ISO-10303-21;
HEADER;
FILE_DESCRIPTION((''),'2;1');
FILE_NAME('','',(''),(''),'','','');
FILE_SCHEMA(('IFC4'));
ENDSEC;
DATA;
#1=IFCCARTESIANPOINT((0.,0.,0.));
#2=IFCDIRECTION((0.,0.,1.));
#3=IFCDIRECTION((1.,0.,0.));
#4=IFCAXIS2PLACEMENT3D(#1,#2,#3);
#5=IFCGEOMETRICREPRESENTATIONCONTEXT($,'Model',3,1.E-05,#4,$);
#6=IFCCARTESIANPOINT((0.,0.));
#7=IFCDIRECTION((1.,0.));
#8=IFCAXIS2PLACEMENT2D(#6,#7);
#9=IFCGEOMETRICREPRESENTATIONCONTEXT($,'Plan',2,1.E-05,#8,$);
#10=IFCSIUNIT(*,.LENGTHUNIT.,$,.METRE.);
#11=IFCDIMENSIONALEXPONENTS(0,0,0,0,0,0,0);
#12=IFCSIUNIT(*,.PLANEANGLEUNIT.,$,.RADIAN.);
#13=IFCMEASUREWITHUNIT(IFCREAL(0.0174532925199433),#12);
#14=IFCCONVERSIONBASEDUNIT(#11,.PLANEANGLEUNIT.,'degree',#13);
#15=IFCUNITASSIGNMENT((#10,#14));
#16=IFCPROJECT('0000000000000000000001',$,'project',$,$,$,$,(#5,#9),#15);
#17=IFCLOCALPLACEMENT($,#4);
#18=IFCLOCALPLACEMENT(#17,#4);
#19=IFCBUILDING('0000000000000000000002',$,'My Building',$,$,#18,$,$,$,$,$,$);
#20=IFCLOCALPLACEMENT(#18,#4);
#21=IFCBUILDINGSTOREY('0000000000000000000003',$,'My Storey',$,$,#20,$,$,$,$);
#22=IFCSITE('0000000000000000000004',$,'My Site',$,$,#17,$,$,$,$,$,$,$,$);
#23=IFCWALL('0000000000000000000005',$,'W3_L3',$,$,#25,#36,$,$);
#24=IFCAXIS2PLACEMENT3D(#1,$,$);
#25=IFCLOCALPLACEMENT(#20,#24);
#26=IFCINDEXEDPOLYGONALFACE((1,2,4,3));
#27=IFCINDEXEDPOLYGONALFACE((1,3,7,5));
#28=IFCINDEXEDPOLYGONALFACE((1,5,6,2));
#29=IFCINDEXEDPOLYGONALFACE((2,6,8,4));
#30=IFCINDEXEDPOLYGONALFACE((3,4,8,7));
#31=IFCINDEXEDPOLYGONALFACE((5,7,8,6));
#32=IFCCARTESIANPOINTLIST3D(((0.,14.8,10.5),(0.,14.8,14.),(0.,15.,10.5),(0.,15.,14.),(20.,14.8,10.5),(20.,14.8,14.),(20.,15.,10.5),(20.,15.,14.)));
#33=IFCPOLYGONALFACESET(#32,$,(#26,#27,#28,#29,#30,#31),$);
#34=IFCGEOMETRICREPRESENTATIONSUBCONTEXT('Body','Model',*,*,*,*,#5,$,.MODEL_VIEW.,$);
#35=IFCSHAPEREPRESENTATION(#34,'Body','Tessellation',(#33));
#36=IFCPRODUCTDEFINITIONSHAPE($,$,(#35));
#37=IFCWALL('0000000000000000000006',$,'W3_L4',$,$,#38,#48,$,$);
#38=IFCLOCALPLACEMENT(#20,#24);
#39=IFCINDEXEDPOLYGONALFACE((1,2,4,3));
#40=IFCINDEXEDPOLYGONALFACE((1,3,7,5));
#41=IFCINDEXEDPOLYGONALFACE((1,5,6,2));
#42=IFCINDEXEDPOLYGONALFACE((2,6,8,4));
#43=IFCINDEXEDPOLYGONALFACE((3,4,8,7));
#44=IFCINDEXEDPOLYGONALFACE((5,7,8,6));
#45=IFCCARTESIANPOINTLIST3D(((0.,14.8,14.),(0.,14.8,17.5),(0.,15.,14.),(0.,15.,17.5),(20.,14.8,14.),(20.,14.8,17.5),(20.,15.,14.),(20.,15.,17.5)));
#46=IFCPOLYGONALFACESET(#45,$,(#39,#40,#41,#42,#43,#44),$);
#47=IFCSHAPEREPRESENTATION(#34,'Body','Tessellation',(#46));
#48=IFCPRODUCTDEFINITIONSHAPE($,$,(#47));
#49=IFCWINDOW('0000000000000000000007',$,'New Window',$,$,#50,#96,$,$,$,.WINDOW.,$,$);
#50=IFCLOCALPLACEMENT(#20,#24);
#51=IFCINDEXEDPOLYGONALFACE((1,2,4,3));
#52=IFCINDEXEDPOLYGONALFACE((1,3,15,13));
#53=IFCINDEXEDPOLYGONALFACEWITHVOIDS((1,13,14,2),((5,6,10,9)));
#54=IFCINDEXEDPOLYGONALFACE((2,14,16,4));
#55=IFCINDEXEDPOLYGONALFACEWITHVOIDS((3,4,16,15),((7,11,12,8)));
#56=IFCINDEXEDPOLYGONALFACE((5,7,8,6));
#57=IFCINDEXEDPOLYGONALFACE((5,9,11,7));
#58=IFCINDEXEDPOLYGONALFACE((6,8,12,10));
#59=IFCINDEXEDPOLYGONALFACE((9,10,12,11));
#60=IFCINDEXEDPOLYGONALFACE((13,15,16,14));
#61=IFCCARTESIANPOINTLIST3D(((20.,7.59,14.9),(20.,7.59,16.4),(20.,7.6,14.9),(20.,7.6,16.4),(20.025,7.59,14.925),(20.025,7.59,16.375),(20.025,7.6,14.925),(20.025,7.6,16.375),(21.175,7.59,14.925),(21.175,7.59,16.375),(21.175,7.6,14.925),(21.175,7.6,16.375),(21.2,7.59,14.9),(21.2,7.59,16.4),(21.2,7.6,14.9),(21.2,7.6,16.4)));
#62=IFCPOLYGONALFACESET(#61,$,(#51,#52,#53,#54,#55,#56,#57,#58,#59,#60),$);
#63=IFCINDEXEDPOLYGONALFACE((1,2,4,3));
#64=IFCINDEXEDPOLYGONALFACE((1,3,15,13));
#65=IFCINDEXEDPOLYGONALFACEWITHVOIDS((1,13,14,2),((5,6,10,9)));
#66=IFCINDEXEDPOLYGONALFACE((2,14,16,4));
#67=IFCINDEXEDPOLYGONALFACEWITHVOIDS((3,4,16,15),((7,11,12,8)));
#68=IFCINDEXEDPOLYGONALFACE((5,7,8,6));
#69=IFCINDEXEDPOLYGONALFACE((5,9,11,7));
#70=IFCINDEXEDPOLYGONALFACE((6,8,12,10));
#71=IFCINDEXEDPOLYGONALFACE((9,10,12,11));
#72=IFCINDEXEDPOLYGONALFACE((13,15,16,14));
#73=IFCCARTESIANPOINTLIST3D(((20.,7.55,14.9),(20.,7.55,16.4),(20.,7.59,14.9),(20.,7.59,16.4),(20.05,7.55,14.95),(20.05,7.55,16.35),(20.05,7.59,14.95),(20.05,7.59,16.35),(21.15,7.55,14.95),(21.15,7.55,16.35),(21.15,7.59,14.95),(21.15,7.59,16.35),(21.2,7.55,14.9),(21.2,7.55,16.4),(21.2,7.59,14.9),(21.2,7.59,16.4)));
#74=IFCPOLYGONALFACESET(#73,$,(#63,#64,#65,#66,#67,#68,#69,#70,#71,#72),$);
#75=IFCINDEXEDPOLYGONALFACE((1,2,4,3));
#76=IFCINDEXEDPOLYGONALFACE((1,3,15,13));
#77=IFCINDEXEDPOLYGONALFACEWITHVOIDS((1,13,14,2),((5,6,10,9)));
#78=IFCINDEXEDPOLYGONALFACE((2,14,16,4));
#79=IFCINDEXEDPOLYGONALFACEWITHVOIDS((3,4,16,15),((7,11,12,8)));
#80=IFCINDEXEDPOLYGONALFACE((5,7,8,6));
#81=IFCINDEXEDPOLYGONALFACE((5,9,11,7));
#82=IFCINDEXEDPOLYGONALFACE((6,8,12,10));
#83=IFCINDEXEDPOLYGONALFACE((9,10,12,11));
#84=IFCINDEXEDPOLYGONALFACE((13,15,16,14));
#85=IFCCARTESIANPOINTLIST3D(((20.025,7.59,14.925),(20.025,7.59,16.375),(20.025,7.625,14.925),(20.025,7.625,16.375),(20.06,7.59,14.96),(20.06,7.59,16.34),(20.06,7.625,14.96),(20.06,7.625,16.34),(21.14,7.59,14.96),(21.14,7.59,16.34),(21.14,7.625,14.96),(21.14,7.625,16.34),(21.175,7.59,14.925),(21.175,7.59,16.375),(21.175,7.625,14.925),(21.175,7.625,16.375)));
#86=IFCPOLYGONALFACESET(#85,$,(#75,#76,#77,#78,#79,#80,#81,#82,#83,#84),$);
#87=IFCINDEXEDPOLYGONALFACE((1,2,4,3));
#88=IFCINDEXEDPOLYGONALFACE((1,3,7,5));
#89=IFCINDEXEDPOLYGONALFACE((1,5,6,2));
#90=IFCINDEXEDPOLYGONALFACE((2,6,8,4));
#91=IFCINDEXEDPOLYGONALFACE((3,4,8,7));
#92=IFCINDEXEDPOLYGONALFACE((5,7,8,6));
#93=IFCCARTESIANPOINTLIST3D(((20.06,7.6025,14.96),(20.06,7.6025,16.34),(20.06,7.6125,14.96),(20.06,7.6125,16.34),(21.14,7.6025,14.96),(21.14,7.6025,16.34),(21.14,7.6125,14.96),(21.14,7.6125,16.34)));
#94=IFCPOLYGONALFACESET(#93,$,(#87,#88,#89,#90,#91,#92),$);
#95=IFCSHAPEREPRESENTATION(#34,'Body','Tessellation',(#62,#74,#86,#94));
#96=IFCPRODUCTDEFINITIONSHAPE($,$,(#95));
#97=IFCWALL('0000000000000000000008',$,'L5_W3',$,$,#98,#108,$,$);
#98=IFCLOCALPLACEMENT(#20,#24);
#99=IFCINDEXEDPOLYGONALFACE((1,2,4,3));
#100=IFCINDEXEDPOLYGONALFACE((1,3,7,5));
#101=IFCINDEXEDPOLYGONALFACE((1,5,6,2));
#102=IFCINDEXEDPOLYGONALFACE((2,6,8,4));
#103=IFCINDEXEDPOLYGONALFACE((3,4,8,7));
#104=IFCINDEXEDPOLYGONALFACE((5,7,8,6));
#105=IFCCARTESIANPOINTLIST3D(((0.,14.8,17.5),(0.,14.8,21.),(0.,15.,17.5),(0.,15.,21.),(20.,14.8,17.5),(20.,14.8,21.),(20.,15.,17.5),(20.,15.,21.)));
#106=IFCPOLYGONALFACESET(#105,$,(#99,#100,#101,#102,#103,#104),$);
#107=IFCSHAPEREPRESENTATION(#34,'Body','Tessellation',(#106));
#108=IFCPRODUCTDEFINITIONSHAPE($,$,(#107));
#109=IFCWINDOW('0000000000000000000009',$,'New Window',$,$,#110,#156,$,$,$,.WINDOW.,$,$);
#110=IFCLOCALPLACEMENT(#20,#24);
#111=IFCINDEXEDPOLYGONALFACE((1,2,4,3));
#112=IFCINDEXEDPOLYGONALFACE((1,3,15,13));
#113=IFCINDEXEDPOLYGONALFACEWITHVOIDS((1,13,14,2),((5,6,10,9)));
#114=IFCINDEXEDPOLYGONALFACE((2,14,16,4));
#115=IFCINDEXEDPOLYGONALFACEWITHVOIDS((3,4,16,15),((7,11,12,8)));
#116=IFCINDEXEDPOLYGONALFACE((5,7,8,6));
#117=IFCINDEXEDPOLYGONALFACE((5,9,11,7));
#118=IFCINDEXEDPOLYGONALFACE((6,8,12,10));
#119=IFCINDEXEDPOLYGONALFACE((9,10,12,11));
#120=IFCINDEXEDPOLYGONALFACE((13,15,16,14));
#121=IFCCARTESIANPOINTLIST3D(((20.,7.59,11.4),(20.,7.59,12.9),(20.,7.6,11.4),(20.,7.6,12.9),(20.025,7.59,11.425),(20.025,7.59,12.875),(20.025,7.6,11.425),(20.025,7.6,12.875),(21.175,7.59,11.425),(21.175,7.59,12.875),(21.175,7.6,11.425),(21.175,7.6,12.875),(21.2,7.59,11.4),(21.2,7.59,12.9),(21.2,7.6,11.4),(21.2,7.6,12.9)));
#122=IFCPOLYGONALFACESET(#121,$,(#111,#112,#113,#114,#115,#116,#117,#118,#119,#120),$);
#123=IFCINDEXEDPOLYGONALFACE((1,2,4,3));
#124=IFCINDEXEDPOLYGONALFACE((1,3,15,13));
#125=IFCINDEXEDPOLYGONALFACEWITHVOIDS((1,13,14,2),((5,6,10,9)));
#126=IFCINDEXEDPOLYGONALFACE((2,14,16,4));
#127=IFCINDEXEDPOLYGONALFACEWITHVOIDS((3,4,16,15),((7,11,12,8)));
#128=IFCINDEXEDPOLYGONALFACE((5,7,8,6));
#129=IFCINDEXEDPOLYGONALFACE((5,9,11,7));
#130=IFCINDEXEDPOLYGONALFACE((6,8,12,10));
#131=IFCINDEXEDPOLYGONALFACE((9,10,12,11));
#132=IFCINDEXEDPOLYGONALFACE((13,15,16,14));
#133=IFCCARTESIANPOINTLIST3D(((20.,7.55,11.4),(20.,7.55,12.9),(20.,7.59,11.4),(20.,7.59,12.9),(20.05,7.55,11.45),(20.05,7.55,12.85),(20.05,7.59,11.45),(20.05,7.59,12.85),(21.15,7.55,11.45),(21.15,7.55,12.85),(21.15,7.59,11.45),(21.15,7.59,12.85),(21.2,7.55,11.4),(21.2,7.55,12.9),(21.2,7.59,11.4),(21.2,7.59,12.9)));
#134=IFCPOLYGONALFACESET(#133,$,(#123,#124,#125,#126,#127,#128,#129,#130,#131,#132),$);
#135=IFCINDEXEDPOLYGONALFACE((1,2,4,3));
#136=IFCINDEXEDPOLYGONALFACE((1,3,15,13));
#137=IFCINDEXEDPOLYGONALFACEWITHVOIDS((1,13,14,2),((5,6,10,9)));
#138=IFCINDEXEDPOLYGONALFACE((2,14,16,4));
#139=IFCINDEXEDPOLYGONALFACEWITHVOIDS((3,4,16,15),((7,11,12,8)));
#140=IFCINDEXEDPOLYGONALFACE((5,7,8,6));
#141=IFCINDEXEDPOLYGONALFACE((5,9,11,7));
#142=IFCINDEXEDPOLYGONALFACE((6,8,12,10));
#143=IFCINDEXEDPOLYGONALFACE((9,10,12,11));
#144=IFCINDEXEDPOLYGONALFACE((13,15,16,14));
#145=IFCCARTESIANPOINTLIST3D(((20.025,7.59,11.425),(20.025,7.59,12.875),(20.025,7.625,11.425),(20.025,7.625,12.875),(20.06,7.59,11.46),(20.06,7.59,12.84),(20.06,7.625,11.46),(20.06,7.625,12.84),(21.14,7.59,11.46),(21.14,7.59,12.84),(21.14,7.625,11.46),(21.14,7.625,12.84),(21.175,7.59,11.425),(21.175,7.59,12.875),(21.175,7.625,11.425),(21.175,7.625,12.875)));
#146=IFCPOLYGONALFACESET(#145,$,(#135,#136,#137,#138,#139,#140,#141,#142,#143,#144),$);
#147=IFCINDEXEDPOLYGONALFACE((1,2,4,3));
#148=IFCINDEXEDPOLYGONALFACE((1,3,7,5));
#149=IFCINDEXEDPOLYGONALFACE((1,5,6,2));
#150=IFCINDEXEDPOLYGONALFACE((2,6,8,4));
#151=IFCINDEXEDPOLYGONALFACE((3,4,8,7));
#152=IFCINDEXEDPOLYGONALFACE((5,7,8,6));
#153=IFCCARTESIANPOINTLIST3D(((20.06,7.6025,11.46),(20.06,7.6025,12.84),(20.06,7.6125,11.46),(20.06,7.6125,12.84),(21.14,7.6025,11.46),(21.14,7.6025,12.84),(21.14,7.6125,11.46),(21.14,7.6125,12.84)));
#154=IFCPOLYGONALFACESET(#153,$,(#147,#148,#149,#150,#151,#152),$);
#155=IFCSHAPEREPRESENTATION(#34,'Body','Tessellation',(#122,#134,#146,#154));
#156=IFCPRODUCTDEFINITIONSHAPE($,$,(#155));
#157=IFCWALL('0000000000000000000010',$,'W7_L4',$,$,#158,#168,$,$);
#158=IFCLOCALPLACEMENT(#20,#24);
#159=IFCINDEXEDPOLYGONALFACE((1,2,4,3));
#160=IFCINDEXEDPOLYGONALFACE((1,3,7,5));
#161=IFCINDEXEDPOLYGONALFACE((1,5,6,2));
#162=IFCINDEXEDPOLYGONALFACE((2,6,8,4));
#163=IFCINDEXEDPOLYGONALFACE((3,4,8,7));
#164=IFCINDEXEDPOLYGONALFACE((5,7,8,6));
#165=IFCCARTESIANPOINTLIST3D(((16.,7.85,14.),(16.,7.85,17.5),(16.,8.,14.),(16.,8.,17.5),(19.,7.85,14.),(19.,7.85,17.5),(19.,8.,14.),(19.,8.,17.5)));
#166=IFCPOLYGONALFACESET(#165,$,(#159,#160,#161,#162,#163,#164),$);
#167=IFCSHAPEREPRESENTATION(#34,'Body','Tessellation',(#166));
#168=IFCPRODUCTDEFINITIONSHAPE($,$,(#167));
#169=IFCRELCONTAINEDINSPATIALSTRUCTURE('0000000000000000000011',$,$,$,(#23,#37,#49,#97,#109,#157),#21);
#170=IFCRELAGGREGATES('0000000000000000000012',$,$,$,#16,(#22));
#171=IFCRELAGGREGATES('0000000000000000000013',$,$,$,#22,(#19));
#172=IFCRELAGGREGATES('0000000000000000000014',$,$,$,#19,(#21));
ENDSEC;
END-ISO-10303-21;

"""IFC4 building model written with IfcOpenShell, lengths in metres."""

from ifc_helpers import new_model, entity, si_unit, converted_unit, frame, origin_with_axes, origin_2d_with_axis, place, context, subcontext, project, spatial, line, indexed_curve, outline, extrude, element, save


model = new_model("IFC4")

# Units and contexts
model_context = context("Model", 3, precision=1e-05, world=origin_with_axes())
plan_context = context("Plan", 2, precision=1e-05, world=origin_2d_with_axis())
body_context = subcontext(model_context, "Body", "Model", "MODEL_VIEW")
ifc_project = project(units=[si_unit("LENGTHUNIT", "METRE"), converted_unit("PLANEANGLEUNIT", "degree", entity("IfcReal", 0.0174532925199433), si_unit("PLANEANGLEUNIT", "RADIAN"), dimensions=[0, 0, 0, 0, 0, 0, 0])], contexts=[model_context, plan_context])

# Site, building, storey
site_placement = place(None, origin_with_axes())
site = spatial("IfcSite", under=ifc_project, at=site_placement, Name="My Site")
building_placement = place(site_placement, origin_with_axes())
building = spatial("IfcBuilding", under=site, at=building_placement, Name="My Building")
storey_placement = place(building_placement, origin_with_axes())
storey = spatial("IfcBuildingStorey", under=building, at=storey_placement, Name="My Storey")

# Walls
for number, where, z_axis, x_axis, name in (
    (1, (20.0, 15.0, 10.5), (0.0, 0.0, 1.0), (-1.0, 0.0, 0.0), "W3_L3"),
    (2, (20.0, 15.0, 14.0), (0.0, 0.0, 1.0), (-1.0, 0.0, 0.0), "W3_L4"),
):
    element("IfcWall", number, at=place(storey_placement, frame(where, z_axis=z_axis, x_axis=x_axis)), inside=storey, Name=name, context=body_context, shape_type="SweptSolid", body=[
        extrude(outline(indexed_curve([(0.0, 0.0), (0.0, 0.2), (20.0, 0.2), (20.0, 0.0), (0.0, 0.0)], self_intersect=False)), origin_with_axes(), (0.0, 0.0, 1.0), 3.5),
    ])

# Window
window_placement = place(storey_placement, frame((20.0, 7.5, 14.9), z_axis=(0.0, 0.0, 1.0), x_axis=(1.0, 0.0, 0.0)))
element("IfcWindow", 3, at=window_placement, inside=storey, Name="New Window", PredefinedType="WINDOW", context=body_context, shape_type="SweptSolid", body=[
    extrude(outline(indexed_curve([(0.0, 0.0), (1.2, 0.0), (1.2, 1.5), (0.0, 1.5)], segments=[line(1, 2, 3, 4, 1)]), holes=[indexed_curve([(0.025, 0.025), (1.175, 0.025), (1.175, 1.475), (0.025, 1.475)], segments=[line(1, 2, 3, 4, 1)])]), frame((0.0, 0.09, 0.0), z_axis=(0.0, -1.0, 0.0), x_axis=(1.0, 0.0, 0.0)), (0.0, 0.0, -1.0), 0.01),
    extrude(outline(indexed_curve([(0.0, 0.0), (1.2, 0.0), (1.2, 1.5), (0.0, 1.5)], segments=[line(1, 2, 3, 4, 1)]), holes=[indexed_curve([(0.05, 0.05), (1.15, 0.05), (1.15, 1.45), (0.05, 1.45)], segments=[line(1, 2, 3, 4, 1)])]), frame((0.0, 0.05, 0.0), z_axis=(0.0, -1.0, 0.0), x_axis=(1.0, 0.0, 0.0)), (0.0, 0.0, -1.0), 0.04),
    extrude(outline(indexed_curve([(0.0, 0.0), (1.15, 0.0), (1.15, 1.45), (0.0, 1.45)], segments=[line(1, 2, 3, 4, 1)]), holes=[indexed_curve([(0.035, 0.035), (1.115, 0.035), (1.115, 1.415), (0.035, 1.415)], segments=[line(1, 2, 3, 4, 1)])]), frame((0.025, 0.09, 0.025), z_axis=(0.0, -1.0, 0.0), x_axis=(1.0, 0.0, 0.0)), (0.0, 0.0, -1.0), 0.035),
    extrude(outline(indexed_curve([(0.035, 0.035), (1.115, 0.035), (1.115, 1.415), (0.035, 1.415)], segments=[line(1, 2, 3, 4, 1)])), frame((0.025, 0.1025, 0.025), z_axis=(0.0, -1.0, 0.0), x_axis=(1.0, 0.0, 0.0)), (0.0, 0.0, -1.0), 0.01),
])

# Wall
for number, where, z_axis, x_axis, name in (
    (4, (20.0, 15.0, 17.5), (0.0, 0.0, 1.0), (-1.0, 0.0, 0.0), "L5_W3"),
):
    element("IfcWall", number, at=place(storey_placement, frame(where, z_axis=z_axis, x_axis=x_axis)), inside=storey, Name=name, context=body_context, shape_type="SweptSolid", body=[
        extrude(outline(indexed_curve([(0.0, 0.0), (0.0, 0.2), (20.0, 0.2), (20.0, 0.0), (0.0, 0.0)], self_intersect=False)), origin_with_axes(), (0.0, 0.0, 1.0), 3.5),
    ])

# Window
for number, where, z_axis, x_axis, name in (
    (5, (20.0, 7.5, 11.4), (0.0, 0.0, 1.0), (1.0, 0.0, 0.0), "New Window"),
):
    element("IfcWindow", number, at=place(storey_placement, frame(where, z_axis=z_axis, x_axis=x_axis)), inside=storey, Name=name, PredefinedType="WINDOW", context=body_context, shape_type="SweptSolid", body=[
        extrude(outline(indexed_curve([(0.0, 0.0), (1.2, 0.0), (1.2, 1.5), (0.0, 1.5)], segments=[line(1, 2, 3, 4, 1)]), holes=[indexed_curve([(0.025, 0.025), (1.175, 0.025), (1.175, 1.475), (0.025, 1.475)], segments=[line(1, 2, 3, 4, 1)])]), frame((0.0, 0.09, 0.0), z_axis=(0.0, -1.0, 0.0), x_axis=(1.0, 0.0, 0.0)), (0.0, 0.0, -1.0), 0.01),
        extrude(outline(indexed_curve([(0.0, 0.0), (1.2, 0.0), (1.2, 1.5), (0.0, 1.5)], segments=[line(1, 2, 3, 4, 1)]), holes=[indexed_curve([(0.05, 0.05), (1.15, 0.05), (1.15, 1.45), (0.05, 1.45)], segments=[line(1, 2, 3, 4, 1)])]), frame((0.0, 0.05, 0.0), z_axis=(0.0, -1.0, 0.0), x_axis=(1.0, 0.0, 0.0)), (0.0, 0.0, -1.0), 0.04),
        extrude(outline(indexed_curve([(0.0, 0.0), (1.15, 0.0), (1.15, 1.45), (0.0, 1.45)], segments=[line(1, 2, 3, 4, 1)]), holes=[indexed_curve([(0.035, 0.035), (1.115, 0.035), (1.115, 1.415), (0.035, 1.415)], segments=[line(1, 2, 3, 4, 1)])]), frame((0.025, 0.09, 0.025), z_axis=(0.0, -1.0, 0.0), x_axis=(1.0, 0.0, 0.0)), (0.0, 0.0, -1.0), 0.035),
        extrude(outline(indexed_curve([(0.035, 0.035), (1.115, 0.035), (1.115, 1.415), (0.035, 1.415)], segments=[line(1, 2, 3, 4, 1)])), frame((0.025, 0.1025, 0.025), z_axis=(0.0, -1.0, 0.0), x_axis=(1.0, 0.0, 0.0)), (0.0, 0.0, -1.0), 0.01),
    ])

# Wall
wall_placement = place(storey_placement, frame((19.0, 8.0, 14.0), z_axis=(0.0, 0.0, 1.0), x_axis=(-1.0, 0.0, 0.0)))
element("IfcWall", 6, at=wall_placement, inside=storey, Name="W7_L4", context=body_context, shape_type="SweptSolid", body=[
    extrude(outline(indexed_curve([(0.0, 0.0), (0.0, 0.15), (3.0, 0.15), (3.0, 0.0), (0.0, 0.0)], self_intersect=False)), origin_with_axes(), (0.0, 0.0, 1.0), 3.5),
])

save(model, "model.ifc")
